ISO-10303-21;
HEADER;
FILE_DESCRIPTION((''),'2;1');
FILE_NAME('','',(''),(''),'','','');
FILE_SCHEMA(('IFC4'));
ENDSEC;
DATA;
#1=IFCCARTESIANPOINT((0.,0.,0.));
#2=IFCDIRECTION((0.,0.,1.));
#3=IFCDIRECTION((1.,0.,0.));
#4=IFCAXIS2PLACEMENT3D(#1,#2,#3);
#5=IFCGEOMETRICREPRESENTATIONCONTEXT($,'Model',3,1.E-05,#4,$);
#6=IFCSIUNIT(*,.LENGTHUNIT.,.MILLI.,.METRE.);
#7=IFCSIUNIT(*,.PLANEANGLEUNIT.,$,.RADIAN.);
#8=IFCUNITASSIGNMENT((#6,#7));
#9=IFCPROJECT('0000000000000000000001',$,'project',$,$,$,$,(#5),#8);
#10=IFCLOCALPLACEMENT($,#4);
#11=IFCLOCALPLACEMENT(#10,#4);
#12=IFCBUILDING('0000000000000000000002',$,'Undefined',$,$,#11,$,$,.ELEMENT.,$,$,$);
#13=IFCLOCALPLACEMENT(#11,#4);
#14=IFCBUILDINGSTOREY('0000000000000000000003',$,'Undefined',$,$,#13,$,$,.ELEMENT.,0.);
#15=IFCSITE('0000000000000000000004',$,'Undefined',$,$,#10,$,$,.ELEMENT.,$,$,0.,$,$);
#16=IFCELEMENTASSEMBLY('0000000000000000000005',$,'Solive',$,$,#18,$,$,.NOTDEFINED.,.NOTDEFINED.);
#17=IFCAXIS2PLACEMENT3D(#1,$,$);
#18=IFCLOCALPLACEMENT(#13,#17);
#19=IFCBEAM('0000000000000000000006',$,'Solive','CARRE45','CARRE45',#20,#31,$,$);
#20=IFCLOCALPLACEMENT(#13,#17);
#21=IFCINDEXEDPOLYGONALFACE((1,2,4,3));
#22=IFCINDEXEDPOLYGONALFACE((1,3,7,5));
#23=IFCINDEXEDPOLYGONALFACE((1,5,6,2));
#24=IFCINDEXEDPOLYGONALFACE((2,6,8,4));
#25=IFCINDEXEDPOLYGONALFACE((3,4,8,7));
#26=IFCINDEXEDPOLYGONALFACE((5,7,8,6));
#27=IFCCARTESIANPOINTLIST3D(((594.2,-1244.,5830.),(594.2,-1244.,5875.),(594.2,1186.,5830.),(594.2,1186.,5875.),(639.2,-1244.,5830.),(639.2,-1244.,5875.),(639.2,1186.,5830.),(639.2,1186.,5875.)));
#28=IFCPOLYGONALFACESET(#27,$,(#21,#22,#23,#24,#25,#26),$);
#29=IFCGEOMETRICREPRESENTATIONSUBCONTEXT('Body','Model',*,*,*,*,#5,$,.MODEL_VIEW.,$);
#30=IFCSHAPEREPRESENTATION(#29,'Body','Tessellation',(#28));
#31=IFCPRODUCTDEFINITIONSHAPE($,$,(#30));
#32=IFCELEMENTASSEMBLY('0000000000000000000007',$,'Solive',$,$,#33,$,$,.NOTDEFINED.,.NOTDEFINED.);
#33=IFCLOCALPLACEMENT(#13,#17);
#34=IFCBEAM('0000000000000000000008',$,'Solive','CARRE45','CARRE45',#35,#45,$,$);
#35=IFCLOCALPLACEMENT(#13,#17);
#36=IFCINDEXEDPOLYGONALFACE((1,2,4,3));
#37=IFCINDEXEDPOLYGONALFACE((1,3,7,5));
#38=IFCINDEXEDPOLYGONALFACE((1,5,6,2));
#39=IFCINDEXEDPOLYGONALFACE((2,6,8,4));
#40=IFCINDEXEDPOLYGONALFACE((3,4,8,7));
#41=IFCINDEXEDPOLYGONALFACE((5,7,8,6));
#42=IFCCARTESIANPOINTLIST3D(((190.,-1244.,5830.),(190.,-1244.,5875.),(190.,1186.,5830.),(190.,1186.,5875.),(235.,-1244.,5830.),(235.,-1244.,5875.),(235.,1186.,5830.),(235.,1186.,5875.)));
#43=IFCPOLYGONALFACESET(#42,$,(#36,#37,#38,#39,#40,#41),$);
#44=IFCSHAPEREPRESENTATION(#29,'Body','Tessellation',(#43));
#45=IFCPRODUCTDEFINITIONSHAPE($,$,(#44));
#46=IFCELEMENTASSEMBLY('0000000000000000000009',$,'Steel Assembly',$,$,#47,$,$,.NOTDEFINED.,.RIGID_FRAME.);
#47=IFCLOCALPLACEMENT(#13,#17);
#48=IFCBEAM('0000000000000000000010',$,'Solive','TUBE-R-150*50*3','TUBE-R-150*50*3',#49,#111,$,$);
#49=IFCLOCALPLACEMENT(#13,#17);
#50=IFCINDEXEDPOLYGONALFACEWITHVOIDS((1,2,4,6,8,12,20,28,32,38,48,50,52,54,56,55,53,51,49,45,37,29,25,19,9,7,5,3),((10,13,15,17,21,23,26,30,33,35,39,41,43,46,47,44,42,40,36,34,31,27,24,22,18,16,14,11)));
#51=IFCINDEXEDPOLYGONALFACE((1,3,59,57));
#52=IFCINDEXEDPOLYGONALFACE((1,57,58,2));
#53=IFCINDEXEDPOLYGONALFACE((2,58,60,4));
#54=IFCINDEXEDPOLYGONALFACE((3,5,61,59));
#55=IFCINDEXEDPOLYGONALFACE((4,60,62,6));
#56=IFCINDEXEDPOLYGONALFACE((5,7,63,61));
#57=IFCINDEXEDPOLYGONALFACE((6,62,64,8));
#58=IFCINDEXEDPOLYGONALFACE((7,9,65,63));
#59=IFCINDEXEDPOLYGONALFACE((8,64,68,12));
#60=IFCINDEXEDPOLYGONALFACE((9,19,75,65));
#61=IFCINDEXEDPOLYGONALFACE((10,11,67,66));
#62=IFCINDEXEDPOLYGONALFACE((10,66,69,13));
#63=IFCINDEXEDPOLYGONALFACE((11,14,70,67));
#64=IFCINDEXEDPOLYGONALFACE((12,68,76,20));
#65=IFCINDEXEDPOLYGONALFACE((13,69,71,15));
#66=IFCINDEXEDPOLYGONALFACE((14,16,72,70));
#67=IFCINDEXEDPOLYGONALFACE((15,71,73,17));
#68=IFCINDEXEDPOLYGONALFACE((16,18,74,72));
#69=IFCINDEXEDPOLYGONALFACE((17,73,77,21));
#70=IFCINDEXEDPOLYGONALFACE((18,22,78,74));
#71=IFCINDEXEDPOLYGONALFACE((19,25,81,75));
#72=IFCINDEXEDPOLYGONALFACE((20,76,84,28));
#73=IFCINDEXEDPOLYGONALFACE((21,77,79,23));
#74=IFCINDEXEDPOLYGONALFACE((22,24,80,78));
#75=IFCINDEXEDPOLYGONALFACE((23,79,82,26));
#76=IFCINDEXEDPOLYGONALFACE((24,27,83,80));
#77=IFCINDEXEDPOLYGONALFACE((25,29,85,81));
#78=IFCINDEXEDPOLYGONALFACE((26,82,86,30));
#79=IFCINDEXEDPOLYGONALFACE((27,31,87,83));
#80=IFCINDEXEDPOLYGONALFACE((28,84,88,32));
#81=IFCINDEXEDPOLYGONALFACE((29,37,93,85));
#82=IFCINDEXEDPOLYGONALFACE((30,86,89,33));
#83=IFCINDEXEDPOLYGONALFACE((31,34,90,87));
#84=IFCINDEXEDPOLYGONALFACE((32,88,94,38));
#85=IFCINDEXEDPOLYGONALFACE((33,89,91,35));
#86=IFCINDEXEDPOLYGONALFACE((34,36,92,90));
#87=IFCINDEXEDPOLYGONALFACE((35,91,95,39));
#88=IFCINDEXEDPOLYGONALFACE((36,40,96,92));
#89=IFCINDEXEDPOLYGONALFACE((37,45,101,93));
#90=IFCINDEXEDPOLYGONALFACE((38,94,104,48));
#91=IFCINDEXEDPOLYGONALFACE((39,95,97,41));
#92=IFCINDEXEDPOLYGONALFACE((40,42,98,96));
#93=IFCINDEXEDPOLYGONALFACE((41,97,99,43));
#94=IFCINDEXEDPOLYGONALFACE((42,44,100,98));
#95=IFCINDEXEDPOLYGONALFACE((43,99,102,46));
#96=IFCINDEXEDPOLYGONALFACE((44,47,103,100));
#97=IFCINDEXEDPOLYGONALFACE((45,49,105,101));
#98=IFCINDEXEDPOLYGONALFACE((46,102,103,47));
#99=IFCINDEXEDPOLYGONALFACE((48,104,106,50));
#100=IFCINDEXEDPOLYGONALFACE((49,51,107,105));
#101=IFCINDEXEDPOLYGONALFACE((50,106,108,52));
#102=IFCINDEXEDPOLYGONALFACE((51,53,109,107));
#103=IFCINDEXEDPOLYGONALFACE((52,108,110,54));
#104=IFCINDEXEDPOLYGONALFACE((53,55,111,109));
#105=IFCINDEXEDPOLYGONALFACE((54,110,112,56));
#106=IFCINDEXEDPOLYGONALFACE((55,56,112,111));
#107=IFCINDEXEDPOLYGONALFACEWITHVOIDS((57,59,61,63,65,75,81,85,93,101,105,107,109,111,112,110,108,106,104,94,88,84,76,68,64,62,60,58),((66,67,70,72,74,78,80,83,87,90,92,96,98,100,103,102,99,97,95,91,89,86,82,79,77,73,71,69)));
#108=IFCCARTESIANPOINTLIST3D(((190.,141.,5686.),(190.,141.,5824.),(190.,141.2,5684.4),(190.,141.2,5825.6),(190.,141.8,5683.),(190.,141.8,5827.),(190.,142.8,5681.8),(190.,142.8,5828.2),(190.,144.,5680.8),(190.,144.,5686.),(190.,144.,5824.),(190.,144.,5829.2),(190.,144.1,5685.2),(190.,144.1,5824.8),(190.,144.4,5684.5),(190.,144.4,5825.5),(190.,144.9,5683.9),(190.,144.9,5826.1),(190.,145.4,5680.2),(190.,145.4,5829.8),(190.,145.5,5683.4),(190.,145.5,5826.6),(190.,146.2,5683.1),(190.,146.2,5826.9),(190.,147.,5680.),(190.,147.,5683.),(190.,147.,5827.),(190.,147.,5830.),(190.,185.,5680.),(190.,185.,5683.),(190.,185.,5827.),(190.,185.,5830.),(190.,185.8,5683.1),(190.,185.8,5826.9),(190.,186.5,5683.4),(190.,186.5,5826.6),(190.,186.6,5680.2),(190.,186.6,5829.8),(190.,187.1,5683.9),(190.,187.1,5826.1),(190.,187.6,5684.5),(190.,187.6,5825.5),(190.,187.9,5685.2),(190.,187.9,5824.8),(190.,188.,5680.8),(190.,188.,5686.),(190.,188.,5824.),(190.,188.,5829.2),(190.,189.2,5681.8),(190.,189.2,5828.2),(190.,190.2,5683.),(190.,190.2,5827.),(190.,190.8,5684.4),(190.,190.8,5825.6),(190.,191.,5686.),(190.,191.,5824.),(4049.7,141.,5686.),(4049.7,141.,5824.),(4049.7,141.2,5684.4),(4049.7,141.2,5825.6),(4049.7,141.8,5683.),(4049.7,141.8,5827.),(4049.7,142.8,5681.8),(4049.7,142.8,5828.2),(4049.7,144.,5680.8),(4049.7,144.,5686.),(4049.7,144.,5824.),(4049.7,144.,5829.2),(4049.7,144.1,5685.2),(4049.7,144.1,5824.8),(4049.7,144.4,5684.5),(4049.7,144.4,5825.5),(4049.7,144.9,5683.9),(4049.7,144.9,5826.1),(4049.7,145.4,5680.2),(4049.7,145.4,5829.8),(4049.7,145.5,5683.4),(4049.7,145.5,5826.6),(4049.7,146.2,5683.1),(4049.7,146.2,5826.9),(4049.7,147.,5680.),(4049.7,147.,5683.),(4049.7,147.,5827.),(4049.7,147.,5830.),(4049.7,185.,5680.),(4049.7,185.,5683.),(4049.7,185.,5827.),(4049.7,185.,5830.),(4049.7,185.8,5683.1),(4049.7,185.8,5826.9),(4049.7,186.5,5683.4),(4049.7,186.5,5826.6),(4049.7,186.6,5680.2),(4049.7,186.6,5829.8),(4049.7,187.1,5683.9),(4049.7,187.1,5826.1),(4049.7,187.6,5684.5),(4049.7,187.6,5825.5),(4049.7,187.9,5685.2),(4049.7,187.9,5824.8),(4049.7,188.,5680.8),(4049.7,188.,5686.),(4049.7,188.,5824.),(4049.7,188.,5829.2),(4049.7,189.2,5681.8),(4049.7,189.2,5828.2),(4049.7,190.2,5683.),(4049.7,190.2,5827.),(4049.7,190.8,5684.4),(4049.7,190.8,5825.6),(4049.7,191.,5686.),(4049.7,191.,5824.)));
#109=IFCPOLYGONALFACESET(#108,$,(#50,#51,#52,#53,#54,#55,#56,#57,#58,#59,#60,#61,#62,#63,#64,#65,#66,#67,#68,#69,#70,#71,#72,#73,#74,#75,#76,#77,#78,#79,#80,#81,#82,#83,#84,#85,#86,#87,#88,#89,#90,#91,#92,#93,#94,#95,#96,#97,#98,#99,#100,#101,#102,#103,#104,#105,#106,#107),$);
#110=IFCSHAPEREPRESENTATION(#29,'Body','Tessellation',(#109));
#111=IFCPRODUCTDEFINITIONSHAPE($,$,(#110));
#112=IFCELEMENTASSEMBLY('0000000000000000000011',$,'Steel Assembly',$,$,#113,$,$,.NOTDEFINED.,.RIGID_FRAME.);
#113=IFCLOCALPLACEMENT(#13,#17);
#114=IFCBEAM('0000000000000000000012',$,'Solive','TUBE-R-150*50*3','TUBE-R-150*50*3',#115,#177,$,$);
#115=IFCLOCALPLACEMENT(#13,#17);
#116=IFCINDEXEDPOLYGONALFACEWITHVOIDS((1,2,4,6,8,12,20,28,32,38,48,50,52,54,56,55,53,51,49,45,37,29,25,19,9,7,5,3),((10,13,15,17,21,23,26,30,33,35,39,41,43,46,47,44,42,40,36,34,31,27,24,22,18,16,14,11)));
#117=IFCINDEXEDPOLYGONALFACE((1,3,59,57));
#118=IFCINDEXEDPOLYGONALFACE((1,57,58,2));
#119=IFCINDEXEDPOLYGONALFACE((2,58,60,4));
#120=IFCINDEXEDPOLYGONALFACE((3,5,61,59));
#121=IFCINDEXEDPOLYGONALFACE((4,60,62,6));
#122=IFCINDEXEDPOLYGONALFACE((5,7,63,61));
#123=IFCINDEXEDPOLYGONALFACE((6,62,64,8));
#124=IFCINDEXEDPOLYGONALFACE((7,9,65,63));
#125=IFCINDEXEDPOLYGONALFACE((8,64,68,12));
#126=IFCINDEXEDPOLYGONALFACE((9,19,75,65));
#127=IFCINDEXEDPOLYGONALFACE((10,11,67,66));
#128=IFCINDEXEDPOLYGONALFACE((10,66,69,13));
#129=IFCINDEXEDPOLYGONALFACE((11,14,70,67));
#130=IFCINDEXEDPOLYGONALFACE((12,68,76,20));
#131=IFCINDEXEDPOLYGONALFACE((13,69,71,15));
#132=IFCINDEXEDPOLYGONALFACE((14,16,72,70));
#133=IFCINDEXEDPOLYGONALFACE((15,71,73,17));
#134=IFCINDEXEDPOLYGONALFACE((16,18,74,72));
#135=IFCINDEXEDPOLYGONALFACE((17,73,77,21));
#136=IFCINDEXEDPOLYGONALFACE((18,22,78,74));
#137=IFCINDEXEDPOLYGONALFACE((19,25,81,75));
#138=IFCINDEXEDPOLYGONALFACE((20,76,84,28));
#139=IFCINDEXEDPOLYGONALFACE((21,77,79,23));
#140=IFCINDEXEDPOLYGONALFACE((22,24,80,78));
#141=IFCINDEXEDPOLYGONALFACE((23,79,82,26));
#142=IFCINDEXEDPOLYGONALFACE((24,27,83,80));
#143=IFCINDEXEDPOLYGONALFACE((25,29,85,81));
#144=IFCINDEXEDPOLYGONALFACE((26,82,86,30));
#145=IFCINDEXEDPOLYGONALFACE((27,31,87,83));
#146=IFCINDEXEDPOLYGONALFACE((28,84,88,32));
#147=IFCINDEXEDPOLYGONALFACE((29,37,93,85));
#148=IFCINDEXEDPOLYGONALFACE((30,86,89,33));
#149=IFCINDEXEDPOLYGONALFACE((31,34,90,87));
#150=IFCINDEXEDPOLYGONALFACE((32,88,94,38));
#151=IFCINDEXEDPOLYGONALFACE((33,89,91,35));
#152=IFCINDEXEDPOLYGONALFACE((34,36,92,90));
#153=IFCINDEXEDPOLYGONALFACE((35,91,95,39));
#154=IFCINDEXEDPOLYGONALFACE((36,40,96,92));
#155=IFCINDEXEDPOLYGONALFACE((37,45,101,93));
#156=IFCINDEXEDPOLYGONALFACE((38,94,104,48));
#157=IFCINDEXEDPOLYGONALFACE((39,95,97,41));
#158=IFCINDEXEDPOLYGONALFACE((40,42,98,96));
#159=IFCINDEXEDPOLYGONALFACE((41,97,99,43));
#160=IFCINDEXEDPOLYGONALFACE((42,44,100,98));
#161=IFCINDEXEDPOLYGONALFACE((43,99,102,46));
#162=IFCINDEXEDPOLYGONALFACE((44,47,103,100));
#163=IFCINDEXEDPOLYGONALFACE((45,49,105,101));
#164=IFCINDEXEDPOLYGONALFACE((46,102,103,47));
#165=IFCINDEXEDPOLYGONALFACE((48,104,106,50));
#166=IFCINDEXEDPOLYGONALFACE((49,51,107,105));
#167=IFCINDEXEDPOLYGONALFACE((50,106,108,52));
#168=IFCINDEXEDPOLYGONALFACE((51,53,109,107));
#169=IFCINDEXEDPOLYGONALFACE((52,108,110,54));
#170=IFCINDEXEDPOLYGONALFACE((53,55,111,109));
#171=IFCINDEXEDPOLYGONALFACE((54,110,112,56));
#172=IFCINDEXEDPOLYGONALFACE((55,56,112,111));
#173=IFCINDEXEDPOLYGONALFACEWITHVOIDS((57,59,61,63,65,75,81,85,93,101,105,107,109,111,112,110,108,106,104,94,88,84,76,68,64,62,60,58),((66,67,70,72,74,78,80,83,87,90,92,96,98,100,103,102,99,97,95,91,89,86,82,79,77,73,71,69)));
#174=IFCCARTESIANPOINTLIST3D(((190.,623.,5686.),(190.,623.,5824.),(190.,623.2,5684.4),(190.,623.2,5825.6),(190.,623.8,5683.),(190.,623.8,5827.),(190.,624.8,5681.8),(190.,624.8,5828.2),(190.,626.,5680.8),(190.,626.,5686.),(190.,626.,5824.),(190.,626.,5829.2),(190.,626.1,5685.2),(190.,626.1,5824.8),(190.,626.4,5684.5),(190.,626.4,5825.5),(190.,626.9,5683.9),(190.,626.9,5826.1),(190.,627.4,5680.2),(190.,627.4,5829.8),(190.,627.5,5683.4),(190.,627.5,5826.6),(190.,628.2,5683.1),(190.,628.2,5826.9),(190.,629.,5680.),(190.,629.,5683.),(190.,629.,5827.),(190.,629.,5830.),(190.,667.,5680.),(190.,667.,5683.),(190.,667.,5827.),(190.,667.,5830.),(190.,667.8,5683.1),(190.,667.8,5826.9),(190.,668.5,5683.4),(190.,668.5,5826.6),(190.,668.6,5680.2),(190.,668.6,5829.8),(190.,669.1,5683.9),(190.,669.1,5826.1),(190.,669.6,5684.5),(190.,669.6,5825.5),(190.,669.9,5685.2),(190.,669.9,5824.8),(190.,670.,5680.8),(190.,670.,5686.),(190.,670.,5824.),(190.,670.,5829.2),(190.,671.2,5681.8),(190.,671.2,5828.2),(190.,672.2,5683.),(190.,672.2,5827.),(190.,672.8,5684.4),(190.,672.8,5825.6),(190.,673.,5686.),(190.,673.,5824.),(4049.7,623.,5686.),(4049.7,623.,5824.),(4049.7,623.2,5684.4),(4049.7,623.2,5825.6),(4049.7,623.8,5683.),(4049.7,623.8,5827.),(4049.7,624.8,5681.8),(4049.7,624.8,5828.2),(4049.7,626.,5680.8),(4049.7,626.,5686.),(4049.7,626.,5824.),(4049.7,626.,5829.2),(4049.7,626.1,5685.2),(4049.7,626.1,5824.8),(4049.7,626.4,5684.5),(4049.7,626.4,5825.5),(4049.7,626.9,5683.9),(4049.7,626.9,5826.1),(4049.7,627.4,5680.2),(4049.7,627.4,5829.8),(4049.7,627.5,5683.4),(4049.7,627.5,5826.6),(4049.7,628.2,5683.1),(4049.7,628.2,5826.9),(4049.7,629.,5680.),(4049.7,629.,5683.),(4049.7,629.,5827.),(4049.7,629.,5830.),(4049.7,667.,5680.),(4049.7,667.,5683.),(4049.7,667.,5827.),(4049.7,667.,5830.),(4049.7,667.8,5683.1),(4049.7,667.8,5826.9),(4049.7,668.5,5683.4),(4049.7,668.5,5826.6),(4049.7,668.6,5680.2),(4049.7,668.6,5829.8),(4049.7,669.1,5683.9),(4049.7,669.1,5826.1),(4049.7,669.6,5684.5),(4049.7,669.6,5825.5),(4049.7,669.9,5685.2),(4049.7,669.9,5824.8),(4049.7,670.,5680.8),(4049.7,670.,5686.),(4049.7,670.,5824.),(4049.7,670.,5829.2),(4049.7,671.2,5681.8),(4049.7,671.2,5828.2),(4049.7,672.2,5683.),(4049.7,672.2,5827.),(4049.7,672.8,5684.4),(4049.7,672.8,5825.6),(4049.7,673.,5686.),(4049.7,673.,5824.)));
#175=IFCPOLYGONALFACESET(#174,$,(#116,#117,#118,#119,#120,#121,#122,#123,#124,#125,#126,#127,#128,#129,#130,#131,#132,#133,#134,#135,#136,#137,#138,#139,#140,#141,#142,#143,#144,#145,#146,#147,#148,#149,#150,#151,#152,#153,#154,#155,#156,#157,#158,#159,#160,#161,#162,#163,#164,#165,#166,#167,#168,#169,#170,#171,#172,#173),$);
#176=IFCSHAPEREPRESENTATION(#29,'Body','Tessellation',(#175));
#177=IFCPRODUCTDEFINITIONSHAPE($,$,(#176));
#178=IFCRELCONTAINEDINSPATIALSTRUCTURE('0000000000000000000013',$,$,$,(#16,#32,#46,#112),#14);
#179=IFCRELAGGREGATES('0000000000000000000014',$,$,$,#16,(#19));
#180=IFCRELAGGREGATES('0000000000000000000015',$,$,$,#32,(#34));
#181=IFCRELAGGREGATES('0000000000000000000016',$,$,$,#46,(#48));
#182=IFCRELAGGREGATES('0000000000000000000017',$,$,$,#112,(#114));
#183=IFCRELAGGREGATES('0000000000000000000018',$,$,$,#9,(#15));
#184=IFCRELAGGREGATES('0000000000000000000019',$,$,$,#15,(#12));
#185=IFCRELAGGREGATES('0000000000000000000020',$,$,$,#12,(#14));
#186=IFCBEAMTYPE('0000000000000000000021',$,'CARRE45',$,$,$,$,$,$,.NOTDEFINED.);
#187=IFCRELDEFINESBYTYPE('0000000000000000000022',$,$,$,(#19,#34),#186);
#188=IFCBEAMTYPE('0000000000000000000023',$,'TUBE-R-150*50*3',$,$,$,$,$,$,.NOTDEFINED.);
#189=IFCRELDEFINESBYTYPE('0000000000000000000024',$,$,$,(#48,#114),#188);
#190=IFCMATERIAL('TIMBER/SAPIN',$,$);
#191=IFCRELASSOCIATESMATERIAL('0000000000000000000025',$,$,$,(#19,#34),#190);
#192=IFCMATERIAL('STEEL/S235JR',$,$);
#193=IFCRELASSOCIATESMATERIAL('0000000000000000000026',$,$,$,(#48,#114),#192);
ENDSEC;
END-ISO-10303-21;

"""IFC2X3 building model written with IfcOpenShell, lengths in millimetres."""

from ifc_helpers import new_model, si_unit, frame, origin_with_axes, origin_2d_with_axis, place, context, subcontext, project, spatial, rectangle, hollow_rectangle, extrude, material, type_object, element, aggregate, save


model = new_model("IFC2X3")

# Units and contexts
model_context = context("Model", 3, precision=1e-05, world=origin_with_axes())
body_context = subcontext(model_context, "Body", "Model", "MODEL_VIEW")
ifc_project = project(units=[si_unit("LENGTHUNIT", "METRE", prefix="MILLI"), si_unit("PLANEANGLEUNIT", "RADIAN")], contexts=[model_context])

# Site, building, storey
site_placement = place(None, origin_with_axes())
site = spatial("IfcSite", under=ifc_project, at=site_placement, Name="Undefined", CompositionType="ELEMENT", RefElevation=0.0)
building_placement = place(site_placement, origin_with_axes())
building = spatial("IfcBuilding", under=site, at=building_placement, Name="Undefined", CompositionType="ELEMENT")
storey_placement = place(building_placement, origin_with_axes())
storey = spatial("IfcBuildingStorey", under=building, at=storey_placement, Name="Undefined", CompositionType="ELEMENT", Elevation=0.0)

# Element assemblies, beams
ifc_material_1 = material(Name="TIMBER/SAPIN")
beam_type_1 = type_object("IfcBeamType", Name="CARRE45", PredefinedType="NOTDEFINED")
assembly_1_placement = place(storey_placement, origin_with_axes())
assembly_1 = element("IfcElementAssembly", 1, at=assembly_1_placement, inside=storey, Name="Solive", AssemblyPlace="NOTDEFINED", PredefinedType="NOTDEFINED")
beam_1_placement = place(assembly_1_placement, frame((616.7, 1186.0, 5852.5), z_axis=(0.0, 0.0, -1.0), x_axis=(0.0, -1.0, 0.0)))
beam_1 = element("IfcBeam", 2, at=beam_1_placement, type_object=beam_type_1, material=ifc_material_1, Name="Solive", Description="CARRE45", ObjectType="CARRE45", context=body_context, shape_type="SweptSolid", body=[
    extrude(rectangle(XDim=45.0, YDim=45.0, at=origin_2d_with_axis()), frame((2430.0, 0.0, 0.0), z_axis=(-1.0, 0.0, 0.0), x_axis=(0.0, -1.0, 0.0)), (0.0, 0.0, 1.0), 2430.0),
])
aggregate(assembly_1, [beam_1])
assembly_2_placement = place(storey_placement, origin_with_axes())
assembly_2 = element("IfcElementAssembly", 3, at=assembly_2_placement, inside=storey, Name="Solive", AssemblyPlace="NOTDEFINED", PredefinedType="NOTDEFINED")
beam_2_placement = place(assembly_2_placement, frame((212.5, 1186.0, 5852.5), z_axis=(0.0, 0.0, -1.0), x_axis=(0.0, -1.0, 0.0)))
beam_2 = element("IfcBeam", 4, at=beam_2_placement, type_object=beam_type_1, material=ifc_material_1, Name="Solive", Description="CARRE45", ObjectType="CARRE45", context=body_context, shape_type="SweptSolid", body=[
    extrude(rectangle(XDim=45.0, YDim=45.0, at=origin_2d_with_axis()), frame((2430.0, 0.0, 0.0), z_axis=(-1.0, 0.0, 0.0), x_axis=(0.0, -1.0, 0.0)), (0.0, 0.0, 1.0), 2430.0),
])
aggregate(assembly_2, [beam_2])
assembly_3_placement = place(storey_placement, origin_with_axes())
assembly_3 = element("IfcElementAssembly", 5, at=assembly_3_placement, inside=storey, Name="Steel Assembly", AssemblyPlace="NOTDEFINED", PredefinedType="RIGID_FRAME")
ifc_material_2 = material(Name="STEEL/S235JR")
beam_type_2 = type_object("IfcBeamType", Name="TUBE-R-150*50*3", PredefinedType="NOTDEFINED")
beam_3_placement = place(assembly_3_placement, frame((190.0, 166.0, 5755.0), z_axis=(0.0, 0.0, 1.0), x_axis=(1.0, 0.0, 0.0)))
beam_3 = element("IfcBeam", 6, at=beam_3_placement, type_object=beam_type_2, material=ifc_material_2, Name="Solive", Description="TUBE-R-150*50*3", ObjectType="TUBE-R-150*50*3", context=body_context, shape_type="SweptSolid", body=[
    extrude(hollow_rectangle(XDim=50.0, YDim=150.0, WallThickness=3.0, InnerFilletRadius=3.0, OuterFilletRadius=6.0, at=origin_2d_with_axis()), frame((3859.7, 0.0, 0.0), z_axis=(-1.0, 0.0, 0.0), x_axis=(0.0, -1.0, 0.0)), (0.0, 0.0, 1.0), 3859.7),
])
aggregate(assembly_3, [beam_3])
assembly_4_placement = place(storey_placement, origin_with_axes())
assembly_4 = element("IfcElementAssembly", 7, at=assembly_4_placement, inside=storey, Name="Steel Assembly", AssemblyPlace="NOTDEFINED", PredefinedType="RIGID_FRAME")
beam_4_placement = place(assembly_4_placement, frame((190.0, 648.0, 5755.0), z_axis=(0.0, 0.0, 1.0), x_axis=(1.0, 0.0, 0.0)))
beam_4 = element("IfcBeam", 8, at=beam_4_placement, type_object=beam_type_2, material=ifc_material_2, Name="Solive", Description="TUBE-R-150*50*3", ObjectType="TUBE-R-150*50*3", context=body_context, shape_type="SweptSolid", body=[
    extrude(hollow_rectangle(XDim=50.0, YDim=150.0, WallThickness=3.0, InnerFilletRadius=3.0, OuterFilletRadius=6.0, at=origin_2d_with_axis()), frame((3859.7, 0.0, 0.0), z_axis=(-1.0, 0.0, 0.0), x_axis=(0.0, -1.0, 0.0)), (0.0, 0.0, 1.0), 3859.7),
])
aggregate(assembly_4, [beam_4])

save(model, "model.ifc")
